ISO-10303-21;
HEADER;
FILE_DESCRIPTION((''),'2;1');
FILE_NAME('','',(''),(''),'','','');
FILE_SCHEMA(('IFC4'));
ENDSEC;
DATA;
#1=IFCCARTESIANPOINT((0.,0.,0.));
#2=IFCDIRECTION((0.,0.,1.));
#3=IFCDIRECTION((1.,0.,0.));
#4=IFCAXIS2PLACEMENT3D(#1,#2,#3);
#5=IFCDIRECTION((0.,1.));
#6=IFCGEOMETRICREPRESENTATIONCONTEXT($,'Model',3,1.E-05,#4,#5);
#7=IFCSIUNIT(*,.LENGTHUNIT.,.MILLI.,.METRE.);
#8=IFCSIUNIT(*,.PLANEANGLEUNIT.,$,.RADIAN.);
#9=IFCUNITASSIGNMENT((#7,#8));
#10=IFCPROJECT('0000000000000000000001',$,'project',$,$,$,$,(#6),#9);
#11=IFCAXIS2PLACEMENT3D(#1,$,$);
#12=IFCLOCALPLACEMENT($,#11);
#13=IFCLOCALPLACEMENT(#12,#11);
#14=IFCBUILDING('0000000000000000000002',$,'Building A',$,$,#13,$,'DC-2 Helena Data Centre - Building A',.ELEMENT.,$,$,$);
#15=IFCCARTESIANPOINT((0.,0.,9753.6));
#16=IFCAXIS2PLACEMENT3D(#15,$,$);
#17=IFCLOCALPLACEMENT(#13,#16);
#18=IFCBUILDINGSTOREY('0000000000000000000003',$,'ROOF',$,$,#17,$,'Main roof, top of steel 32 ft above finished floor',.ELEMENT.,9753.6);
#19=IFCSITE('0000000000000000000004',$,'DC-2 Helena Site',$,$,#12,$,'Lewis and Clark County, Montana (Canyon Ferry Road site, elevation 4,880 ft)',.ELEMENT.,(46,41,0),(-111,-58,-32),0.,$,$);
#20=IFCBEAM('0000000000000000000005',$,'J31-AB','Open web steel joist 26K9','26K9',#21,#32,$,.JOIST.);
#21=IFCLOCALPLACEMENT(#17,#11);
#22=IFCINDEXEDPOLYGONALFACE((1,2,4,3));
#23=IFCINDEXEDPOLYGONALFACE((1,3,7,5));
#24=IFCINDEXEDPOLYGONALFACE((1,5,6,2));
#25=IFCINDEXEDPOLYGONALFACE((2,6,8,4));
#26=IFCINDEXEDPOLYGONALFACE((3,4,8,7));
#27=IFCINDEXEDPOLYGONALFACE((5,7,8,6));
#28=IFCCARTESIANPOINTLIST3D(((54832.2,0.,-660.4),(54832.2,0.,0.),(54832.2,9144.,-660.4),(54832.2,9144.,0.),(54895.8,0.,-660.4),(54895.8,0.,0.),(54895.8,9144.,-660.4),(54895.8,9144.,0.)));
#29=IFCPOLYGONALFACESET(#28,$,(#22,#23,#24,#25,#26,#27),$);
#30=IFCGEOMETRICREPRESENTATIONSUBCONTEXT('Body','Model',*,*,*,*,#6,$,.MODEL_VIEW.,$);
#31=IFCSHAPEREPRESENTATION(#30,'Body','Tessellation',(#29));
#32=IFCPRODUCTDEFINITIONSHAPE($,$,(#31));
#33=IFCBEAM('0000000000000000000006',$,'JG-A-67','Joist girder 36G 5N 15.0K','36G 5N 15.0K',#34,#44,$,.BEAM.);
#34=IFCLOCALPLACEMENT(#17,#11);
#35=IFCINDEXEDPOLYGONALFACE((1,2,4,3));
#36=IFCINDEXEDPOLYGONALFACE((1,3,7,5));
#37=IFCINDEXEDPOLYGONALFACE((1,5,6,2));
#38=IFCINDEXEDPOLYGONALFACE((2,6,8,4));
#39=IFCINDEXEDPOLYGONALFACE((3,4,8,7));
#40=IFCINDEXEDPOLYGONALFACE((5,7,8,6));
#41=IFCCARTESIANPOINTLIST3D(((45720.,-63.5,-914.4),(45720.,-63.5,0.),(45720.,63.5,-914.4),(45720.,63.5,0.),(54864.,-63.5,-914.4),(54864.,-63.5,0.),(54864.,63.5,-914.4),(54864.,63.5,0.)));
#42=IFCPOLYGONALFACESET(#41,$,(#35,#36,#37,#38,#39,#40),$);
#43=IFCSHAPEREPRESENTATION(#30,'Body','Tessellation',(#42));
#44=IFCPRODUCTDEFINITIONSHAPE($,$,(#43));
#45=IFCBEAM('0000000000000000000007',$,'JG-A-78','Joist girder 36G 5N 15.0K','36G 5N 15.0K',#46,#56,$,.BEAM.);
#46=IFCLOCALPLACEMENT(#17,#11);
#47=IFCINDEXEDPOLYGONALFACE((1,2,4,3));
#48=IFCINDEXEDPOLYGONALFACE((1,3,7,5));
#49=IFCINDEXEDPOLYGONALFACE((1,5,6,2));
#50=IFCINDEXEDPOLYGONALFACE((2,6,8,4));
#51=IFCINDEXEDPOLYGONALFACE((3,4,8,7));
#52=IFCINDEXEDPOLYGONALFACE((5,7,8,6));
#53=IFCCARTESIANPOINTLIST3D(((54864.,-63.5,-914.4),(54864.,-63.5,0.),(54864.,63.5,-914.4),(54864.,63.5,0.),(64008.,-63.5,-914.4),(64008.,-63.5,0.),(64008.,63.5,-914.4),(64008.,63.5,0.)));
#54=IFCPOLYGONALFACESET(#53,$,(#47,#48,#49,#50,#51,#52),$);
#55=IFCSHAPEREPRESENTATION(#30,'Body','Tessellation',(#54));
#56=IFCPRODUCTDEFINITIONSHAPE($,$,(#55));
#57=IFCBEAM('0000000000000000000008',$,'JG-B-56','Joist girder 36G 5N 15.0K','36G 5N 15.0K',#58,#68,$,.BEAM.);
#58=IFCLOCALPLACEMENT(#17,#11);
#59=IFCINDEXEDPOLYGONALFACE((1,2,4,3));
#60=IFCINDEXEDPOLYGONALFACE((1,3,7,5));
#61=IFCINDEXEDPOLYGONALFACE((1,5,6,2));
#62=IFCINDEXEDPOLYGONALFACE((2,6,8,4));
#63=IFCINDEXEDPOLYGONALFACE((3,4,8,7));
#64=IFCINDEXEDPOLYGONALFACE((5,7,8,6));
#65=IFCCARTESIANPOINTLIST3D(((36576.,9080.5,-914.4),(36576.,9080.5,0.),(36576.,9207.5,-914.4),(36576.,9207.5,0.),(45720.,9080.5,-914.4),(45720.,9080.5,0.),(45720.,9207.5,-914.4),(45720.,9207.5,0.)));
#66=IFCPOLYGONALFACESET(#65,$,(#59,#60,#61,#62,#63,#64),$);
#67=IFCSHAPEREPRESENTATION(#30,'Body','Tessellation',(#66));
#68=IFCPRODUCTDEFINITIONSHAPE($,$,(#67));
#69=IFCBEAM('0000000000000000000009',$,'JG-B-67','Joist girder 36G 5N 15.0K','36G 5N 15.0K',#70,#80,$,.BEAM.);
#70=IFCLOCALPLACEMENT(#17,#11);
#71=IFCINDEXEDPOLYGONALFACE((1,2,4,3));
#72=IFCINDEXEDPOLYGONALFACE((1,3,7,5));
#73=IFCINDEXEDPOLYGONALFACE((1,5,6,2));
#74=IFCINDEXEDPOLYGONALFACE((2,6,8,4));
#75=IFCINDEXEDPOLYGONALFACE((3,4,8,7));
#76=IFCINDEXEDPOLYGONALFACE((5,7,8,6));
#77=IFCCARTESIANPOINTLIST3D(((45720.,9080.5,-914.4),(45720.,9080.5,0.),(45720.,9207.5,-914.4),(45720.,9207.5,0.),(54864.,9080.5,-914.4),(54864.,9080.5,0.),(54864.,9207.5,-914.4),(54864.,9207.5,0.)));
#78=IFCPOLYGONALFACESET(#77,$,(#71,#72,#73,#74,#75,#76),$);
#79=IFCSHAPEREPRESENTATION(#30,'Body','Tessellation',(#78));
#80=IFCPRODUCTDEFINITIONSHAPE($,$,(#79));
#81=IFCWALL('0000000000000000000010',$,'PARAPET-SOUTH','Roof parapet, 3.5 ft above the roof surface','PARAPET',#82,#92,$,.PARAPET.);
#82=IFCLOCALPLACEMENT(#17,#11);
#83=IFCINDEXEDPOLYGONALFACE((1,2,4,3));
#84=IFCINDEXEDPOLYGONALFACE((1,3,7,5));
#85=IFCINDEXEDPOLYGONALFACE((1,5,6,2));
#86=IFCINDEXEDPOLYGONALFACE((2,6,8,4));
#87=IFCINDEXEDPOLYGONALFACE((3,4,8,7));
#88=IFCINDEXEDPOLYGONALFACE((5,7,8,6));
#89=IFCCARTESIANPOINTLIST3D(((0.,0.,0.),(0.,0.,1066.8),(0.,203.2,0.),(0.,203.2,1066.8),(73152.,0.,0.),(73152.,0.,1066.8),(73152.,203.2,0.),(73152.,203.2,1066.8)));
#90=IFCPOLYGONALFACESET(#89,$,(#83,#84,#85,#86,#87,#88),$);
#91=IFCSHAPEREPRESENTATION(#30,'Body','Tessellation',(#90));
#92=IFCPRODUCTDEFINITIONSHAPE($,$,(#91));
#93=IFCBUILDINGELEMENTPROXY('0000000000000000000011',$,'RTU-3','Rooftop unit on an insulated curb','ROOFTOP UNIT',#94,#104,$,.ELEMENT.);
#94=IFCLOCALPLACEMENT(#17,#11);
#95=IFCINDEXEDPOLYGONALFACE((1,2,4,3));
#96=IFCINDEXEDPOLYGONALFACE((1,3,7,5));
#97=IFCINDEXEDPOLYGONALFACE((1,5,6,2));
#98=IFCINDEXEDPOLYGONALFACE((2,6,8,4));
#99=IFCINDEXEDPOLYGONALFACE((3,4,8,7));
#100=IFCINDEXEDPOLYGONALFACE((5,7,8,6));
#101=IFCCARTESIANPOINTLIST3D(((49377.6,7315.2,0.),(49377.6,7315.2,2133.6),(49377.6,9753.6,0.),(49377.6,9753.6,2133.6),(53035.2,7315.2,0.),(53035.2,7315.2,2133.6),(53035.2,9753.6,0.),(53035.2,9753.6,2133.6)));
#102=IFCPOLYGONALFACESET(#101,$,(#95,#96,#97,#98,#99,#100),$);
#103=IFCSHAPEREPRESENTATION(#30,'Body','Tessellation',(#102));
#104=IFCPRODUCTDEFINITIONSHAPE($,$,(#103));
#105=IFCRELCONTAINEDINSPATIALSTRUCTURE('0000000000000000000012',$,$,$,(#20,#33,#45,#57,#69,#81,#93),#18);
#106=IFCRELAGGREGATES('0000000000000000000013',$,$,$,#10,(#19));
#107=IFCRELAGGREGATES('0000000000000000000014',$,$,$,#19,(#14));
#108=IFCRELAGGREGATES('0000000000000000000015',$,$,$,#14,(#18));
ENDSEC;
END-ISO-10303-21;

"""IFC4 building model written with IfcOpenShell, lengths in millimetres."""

from ifc_helpers import new_model, si_unit, direction, frame, origin, origin_with_axes, origin_2d, place, context, subcontext, project, spatial, rectangle, extrude, element, save


model = new_model("IFC4")

# Units and contexts
model_context = context("Model", 3, precision=1e-05, world=origin_with_axes(), true_north=direction((0.0, 1.0)))
body_context = subcontext(model_context, "Body", "Model", "MODEL_VIEW")
ifc_project = project(units=[si_unit("LENGTHUNIT", "METRE", prefix="MILLI"), si_unit("PLANEANGLEUNIT", "RADIAN")], contexts=[model_context])

# Site, building, storey
site_placement = place(None, origin())
site = spatial("IfcSite", under=ifc_project, at=site_placement, Name="DC-2 Helena Site", LongName="Lewis and Clark County, Montana (Canyon Ferry Road site, elevation 4,880 ft)", CompositionType="ELEMENT", RefLatitude=(46, 41, 0), RefLongitude=(-111, -58, -32), RefElevation=0.0)
building_placement = place(site_placement, origin())
building = spatial("IfcBuilding", under=site, at=building_placement, Name="Building A", LongName="DC-2 Helena Data Centre - Building A", CompositionType="ELEMENT")
storey_placement = place(building_placement, frame((0.0, 0.0, 9753.6)))
storey = spatial("IfcBuildingStorey", under=building, at=storey_placement, Name="ROOF", LongName="Main roof, top of steel 32 ft above finished floor", CompositionType="ELEMENT", Elevation=9753.6)

# Beams
placement_1 = place(storey_placement, frame((45720.0, 0.0, 0.0)))
placement_2 = place(storey_placement, frame((45720.0, 9144.0, 0.0)))
placement_3 = place(storey_placement, frame((54864.0, 0.0, 0.0)))
element("IfcBeam", 1, at=placement_3, inside=storey, Name="J31-AB", Description="Open web steel joist 26K9", ObjectType="26K9", PredefinedType="JOIST", context=body_context, shape_type="SweptSolid", body=[
    extrude(rectangle(XDim=63.5, YDim=660.4, at=origin_2d()), frame((0.0, 0.0, -330.2), z_axis=(0.0, 1.0, 0.0), x_axis=(1.0, 0.0, 0.0)), (0.0, 0.0, 1.0), 9144.0),
])
element("IfcBeam", 2, at=placement_1, inside=storey, Name="JG-A-67", Description="Joist girder 36G 5N 15.0K", ObjectType="36G 5N 15.0K", PredefinedType="BEAM", context=body_context, shape_type="SweptSolid", body=[
    extrude(rectangle(XDim=127.0, YDim=914.4, at=origin_2d()), frame((0.0, 0.0, -457.2), z_axis=(1.0, 0.0, 0.0), x_axis=(0.0, 1.0, 0.0)), (0.0, 0.0, 1.0), 9144.0),
])
element("IfcBeam", 3, at=placement_3, inside=storey, Name="JG-A-78", Description="Joist girder 36G 5N 15.0K", ObjectType="36G 5N 15.0K", PredefinedType="BEAM", context=body_context, shape_type="SweptSolid", body=[
    extrude(rectangle(XDim=127.0, YDim=914.4, at=origin_2d()), frame((0.0, 0.0, -457.2), z_axis=(1.0, 0.0, 0.0), x_axis=(0.0, 1.0, 0.0)), (0.0, 0.0, 1.0), 9144.0),
])
beam_1_placement = place(storey_placement, frame((36576.0, 9144.0, 0.0)))
element("IfcBeam", 4, at=beam_1_placement, inside=storey, Name="JG-B-56", Description="Joist girder 36G 5N 15.0K", ObjectType="36G 5N 15.0K", PredefinedType="BEAM", context=body_context, shape_type="SweptSolid", body=[
    extrude(rectangle(XDim=127.0, YDim=914.4, at=origin_2d()), frame((0.0, 0.0, -457.2), z_axis=(1.0, 0.0, 0.0), x_axis=(0.0, 1.0, 0.0)), (0.0, 0.0, 1.0), 9144.0),
])
element("IfcBeam", 5, at=placement_2, inside=storey, Name="JG-B-67", Description="Joist girder 36G 5N 15.0K", ObjectType="36G 5N 15.0K", PredefinedType="BEAM", context=body_context, shape_type="SweptSolid", body=[
    extrude(rectangle(XDim=127.0, YDim=914.4, at=origin_2d()), frame((0.0, 0.0, -457.2), z_axis=(1.0, 0.0, 0.0), x_axis=(0.0, 1.0, 0.0)), (0.0, 0.0, 1.0), 9144.0),
])

# Wall
wall_placement = place(storey_placement, frame((36576.0, 101.6, 0.0)))
element("IfcWall", 6, at=wall_placement, inside=storey, Name="PARAPET-SOUTH", Description="Roof parapet, 3.5 ft above the roof surface", ObjectType="PARAPET", PredefinedType="PARAPET", context=body_context, shape_type="SweptSolid", body=[
    extrude(rectangle(XDim=73152.0, YDim=203.2, at=origin_2d()), origin(), (0.0, 0.0, 1.0), 1066.8),
])

# Building element proxy
proxy_placement = place(storey_placement, frame((51206.4, 8534.4, 0.0)))
element("IfcBuildingElementProxy", 7, at=proxy_placement, inside=storey, Name="RTU-3", Description="Rooftop unit on an insulated curb", ObjectType="ROOFTOP UNIT", PredefinedType="ELEMENT", context=body_context, shape_type="SweptSolid", body=[
    extrude(rectangle(XDim=3657.6, YDim=2438.4, at=origin_2d()), origin(), (0.0, 0.0, 1.0), 2133.6),
])

save(model, "model.ifc")
